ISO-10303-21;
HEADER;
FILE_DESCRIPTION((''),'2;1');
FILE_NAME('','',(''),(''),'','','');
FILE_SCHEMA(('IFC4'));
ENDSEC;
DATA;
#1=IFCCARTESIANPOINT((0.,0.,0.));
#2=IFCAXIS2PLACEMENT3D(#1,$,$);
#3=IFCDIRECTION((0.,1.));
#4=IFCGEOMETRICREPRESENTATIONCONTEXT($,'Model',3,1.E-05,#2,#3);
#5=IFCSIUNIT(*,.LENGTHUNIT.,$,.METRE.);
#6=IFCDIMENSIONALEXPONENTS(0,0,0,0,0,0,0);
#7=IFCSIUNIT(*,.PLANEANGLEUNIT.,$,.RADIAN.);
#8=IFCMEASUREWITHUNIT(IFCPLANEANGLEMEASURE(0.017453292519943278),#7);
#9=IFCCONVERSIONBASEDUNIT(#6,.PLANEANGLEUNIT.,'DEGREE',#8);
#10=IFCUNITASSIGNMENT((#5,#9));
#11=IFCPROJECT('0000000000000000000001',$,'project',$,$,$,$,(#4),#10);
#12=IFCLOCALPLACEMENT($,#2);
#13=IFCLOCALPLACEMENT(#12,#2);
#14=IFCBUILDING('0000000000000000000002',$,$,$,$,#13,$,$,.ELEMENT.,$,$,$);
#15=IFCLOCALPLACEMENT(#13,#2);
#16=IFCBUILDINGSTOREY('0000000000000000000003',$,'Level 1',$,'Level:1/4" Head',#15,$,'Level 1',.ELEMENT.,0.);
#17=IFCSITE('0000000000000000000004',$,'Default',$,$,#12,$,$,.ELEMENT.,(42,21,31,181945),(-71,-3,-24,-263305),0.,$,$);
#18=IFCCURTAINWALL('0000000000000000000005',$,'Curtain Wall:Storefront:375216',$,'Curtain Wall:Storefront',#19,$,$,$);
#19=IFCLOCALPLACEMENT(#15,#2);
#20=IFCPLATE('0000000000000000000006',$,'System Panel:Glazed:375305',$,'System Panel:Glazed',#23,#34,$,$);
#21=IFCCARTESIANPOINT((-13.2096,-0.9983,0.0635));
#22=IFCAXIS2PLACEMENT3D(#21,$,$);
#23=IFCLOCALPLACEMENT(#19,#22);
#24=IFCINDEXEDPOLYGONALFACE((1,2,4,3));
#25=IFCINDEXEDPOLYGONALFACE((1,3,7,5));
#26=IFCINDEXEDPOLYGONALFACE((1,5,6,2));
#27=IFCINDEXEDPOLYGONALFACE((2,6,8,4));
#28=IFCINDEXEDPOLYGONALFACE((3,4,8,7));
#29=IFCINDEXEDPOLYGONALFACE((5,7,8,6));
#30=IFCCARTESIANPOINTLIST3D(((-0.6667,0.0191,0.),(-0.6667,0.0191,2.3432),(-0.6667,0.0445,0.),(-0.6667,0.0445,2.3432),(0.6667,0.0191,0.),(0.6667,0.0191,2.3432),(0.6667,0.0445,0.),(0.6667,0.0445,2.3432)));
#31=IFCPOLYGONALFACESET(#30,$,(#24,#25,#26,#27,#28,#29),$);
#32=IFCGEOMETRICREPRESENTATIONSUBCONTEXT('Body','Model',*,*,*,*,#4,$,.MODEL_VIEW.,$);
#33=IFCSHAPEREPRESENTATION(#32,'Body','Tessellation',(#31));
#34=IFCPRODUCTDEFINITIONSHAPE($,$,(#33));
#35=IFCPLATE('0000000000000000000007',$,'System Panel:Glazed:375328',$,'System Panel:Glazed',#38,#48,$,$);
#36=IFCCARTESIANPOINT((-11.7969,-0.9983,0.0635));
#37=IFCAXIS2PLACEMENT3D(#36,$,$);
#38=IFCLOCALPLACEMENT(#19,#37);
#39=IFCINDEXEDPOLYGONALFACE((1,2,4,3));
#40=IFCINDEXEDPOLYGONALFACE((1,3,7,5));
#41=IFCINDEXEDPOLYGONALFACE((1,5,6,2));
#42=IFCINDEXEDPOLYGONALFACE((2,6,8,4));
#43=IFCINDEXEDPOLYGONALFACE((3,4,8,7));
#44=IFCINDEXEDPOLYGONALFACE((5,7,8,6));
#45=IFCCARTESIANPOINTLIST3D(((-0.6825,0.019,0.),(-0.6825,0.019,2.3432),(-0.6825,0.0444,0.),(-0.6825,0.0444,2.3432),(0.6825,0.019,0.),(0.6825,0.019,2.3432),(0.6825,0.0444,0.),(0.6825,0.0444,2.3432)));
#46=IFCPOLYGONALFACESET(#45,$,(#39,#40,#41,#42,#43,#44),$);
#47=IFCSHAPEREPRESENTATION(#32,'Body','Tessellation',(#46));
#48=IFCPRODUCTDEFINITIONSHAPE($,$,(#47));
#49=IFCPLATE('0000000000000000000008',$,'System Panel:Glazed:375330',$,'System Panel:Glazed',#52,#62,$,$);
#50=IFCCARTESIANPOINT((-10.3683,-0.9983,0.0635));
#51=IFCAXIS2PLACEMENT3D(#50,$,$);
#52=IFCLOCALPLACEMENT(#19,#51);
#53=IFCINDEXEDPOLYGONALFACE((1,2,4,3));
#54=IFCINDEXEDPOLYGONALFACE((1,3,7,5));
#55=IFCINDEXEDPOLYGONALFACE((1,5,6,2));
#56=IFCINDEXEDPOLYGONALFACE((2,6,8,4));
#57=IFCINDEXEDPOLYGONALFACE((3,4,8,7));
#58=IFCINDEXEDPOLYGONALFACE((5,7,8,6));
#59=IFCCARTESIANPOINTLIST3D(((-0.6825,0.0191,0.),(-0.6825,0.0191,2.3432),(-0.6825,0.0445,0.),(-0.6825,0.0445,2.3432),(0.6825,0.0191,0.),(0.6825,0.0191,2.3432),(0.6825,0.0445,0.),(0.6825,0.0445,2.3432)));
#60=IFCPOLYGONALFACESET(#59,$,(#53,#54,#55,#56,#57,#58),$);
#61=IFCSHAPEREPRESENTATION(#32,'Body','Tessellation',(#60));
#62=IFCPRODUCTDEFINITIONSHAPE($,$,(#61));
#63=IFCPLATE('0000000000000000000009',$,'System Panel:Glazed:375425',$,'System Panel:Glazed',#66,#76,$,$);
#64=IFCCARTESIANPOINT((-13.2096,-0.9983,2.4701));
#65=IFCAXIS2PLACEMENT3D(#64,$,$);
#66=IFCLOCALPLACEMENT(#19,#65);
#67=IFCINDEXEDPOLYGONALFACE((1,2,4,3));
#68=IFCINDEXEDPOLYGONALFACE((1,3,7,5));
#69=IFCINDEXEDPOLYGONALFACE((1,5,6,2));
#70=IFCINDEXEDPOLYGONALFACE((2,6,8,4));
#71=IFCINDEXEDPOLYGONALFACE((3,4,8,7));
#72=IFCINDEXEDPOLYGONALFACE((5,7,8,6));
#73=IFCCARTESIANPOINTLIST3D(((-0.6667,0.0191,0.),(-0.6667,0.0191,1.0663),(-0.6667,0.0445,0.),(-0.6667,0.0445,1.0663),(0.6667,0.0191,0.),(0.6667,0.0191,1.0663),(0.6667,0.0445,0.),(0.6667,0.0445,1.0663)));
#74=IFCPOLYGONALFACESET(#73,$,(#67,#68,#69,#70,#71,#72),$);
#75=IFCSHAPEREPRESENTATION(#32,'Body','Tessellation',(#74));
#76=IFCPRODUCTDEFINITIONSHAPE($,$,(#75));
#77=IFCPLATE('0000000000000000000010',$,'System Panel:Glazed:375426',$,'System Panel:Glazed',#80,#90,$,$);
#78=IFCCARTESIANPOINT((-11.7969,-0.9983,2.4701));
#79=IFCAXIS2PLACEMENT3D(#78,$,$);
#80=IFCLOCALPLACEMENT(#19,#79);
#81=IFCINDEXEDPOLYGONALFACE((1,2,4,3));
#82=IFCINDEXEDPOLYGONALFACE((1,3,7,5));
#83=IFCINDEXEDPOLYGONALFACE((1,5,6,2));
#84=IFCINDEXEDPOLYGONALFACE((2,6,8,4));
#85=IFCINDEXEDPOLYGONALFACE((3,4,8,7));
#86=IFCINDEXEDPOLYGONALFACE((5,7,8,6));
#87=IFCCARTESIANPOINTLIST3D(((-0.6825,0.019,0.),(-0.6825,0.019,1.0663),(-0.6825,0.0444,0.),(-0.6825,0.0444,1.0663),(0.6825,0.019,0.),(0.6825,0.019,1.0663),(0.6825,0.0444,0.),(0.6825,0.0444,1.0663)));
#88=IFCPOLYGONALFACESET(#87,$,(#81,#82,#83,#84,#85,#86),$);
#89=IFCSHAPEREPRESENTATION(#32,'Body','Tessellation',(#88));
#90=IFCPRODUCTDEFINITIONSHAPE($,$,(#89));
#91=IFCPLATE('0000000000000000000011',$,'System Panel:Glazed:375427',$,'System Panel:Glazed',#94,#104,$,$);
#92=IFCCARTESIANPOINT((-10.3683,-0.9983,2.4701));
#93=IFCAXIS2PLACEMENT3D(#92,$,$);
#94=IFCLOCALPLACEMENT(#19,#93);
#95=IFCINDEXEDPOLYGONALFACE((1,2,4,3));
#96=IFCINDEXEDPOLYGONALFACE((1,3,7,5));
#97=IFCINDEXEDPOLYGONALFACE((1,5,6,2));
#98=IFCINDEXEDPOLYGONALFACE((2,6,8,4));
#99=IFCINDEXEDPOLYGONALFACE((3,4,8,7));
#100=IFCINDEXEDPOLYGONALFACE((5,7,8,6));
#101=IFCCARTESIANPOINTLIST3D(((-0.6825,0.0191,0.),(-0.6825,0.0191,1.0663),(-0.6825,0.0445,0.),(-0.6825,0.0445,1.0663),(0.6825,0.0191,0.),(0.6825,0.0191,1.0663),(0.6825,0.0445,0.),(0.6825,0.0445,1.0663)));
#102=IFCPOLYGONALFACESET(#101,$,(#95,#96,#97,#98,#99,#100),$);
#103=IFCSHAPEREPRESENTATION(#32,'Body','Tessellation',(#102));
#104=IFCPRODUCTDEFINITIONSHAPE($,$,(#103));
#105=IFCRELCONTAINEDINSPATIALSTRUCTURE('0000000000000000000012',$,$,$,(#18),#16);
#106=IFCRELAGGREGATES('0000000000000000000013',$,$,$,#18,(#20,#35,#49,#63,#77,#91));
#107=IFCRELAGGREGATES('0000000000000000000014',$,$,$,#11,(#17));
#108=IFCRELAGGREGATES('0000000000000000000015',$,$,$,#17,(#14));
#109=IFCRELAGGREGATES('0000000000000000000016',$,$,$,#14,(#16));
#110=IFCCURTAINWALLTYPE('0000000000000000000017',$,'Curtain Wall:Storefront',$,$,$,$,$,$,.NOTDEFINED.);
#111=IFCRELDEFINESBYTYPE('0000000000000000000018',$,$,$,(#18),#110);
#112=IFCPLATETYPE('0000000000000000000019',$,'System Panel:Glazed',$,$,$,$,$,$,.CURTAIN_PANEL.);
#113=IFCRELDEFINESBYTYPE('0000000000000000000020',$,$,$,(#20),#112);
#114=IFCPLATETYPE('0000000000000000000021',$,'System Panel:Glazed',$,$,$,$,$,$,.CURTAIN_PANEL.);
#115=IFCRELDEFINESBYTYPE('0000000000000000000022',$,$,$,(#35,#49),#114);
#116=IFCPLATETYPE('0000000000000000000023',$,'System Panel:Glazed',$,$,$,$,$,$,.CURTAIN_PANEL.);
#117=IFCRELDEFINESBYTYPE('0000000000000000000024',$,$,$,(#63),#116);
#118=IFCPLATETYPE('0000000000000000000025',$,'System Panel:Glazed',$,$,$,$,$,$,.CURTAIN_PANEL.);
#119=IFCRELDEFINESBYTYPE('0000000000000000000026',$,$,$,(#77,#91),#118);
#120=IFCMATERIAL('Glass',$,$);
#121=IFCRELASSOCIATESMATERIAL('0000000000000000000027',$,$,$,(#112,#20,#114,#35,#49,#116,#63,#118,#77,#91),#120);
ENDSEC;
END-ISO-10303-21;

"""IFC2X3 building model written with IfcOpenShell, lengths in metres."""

from ifc_helpers import new_model, entity, si_unit, converted_unit, direction, frame, frame_2d, origin, place, context, subcontext, project, spatial, rectangle, extrude, source, transform, mapped, material, type_object, type_shapes, element, aggregate, save


model = new_model("IFC2X3")

# Units and contexts
model_context = context("Model", 3, precision=1e-05, world=origin(), true_north=direction((0.0, 1.0)))
body_context = subcontext(model_context, "Body", "Model", "MODEL_VIEW")
ifc_project = project(units=[si_unit("LENGTHUNIT", "METRE"), converted_unit("PLANEANGLEUNIT", "DEGREE", entity("IfcPlaneAngleMeasure", 0.017453292519943278), si_unit("PLANEANGLEUNIT", "RADIAN"), dimensions=[0, 0, 0, 0, 0, 0, 0])], contexts=[model_context])

# Site, building, storey
site_placement = place(None, origin())
site = spatial("IfcSite", under=ifc_project, at=site_placement, Name="Default", CompositionType="ELEMENT", RefLatitude=(42, 21, 31, 181945), RefLongitude=(-71, -3, -24, -263305), RefElevation=0.0)
building_placement = place(site_placement, origin())
building = spatial("IfcBuilding", under=site, at=building_placement, CompositionType="ELEMENT")
storey_placement = place(building_placement, origin())
storey = spatial("IfcBuildingStorey", under=building, at=storey_placement, Name="Level 1", ObjectType="Level:1/4\" Head", LongName="Level 1", CompositionType="ELEMENT", Elevation=0.0)

# Curtain wall, plates
curtain_wall_type = type_object("IfcCurtainWallType", Name="Curtain Wall:Storefront", PredefinedType="NOTDEFINED")
curtain_wall_placement = place(storey_placement, origin())
curtain_wall = element("IfcCurtainWall", 1, at=curtain_wall_placement, inside=storey, type_object=curtain_wall_type, Name="Curtain Wall:Storefront:375216", ObjectType="Curtain Wall:Storefront")
ifc_material_1 = material(Name="Glass")
plate_type_1 = type_object("IfcPlateType", Name="System Panel:Glazed", PredefinedType="CURTAIN_PANEL", material=ifc_material_1)
shared_shape_1 = source(origin(), body_context, "Body", "SweptSolid", [
    extrude(rectangle(XDim=0.0254, YDim=1.3333, at=frame_2d((0.0, 0.0), x_axis=(1.0, 0.0))), frame((0.0, 0.0318, 0.0), z_axis=(0.0, 0.0, 1.0), x_axis=(0.0, 1.0, 0.0)), (0.0, 0.0, 1.0), 2.3432),
])
type_shapes(plate_type_1, [shared_shape_1])
plate_1_placement = place(curtain_wall_placement, frame((-13.2096, -0.9983, 0.0635)))
plate_1 = element("IfcPlate", 2, at=plate_1_placement, type_object=plate_type_1, material=ifc_material_1, Name="System Panel:Glazed:375305", ObjectType="System Panel:Glazed", context=body_context, shape_type="MappedRepresentation", body=[
    mapped(shared_shape_1, transform((0.0, 0.0, 0.0), scale=1.0)),
])
plate_type_2 = type_object("IfcPlateType", Name="System Panel:Glazed", PredefinedType="CURTAIN_PANEL", material=ifc_material_1)
shared_shape_2 = source(origin(), body_context, "Body", "SweptSolid", [
    extrude(rectangle(XDim=0.0254, YDim=1.3651, at=frame_2d((0.0, 0.0), x_axis=(1.0, 0.0))), frame((0.0, 0.0318, 0.0), z_axis=(0.0, 0.0, 1.0), x_axis=(0.0, 1.0, 0.0)), (0.0, 0.0, 1.0), 2.3432),
])
type_shapes(plate_type_2, [shared_shape_2])
plate_2_placement = place(curtain_wall_placement, frame((-11.7969, -0.9983, 0.0635)))
plate_2 = element("IfcPlate", 3, at=plate_2_placement, type_object=plate_type_2, material=ifc_material_1, Name="System Panel:Glazed:375328", ObjectType="System Panel:Glazed", context=body_context, shape_type="MappedRepresentation", body=[
    mapped(shared_shape_2, transform((0.0, 0.0, 0.0), scale=1.0)),
])
plate_3_placement = place(curtain_wall_placement, frame((-10.3683, -0.9983, 0.0635)))
plate_3 = element("IfcPlate", 4, at=plate_3_placement, type_object=plate_type_2, material=ifc_material_1, Name="System Panel:Glazed:375330", ObjectType="System Panel:Glazed", context=body_context, shape_type="MappedRepresentation", body=[
    mapped(shared_shape_2, transform((0.0, 0.0, 0.0), scale=1.0)),
])
plate_type_3 = type_object("IfcPlateType", Name="System Panel:Glazed", PredefinedType="CURTAIN_PANEL", material=ifc_material_1)
shared_shape_3 = source(origin(), body_context, "Body", "SweptSolid", [
    extrude(rectangle(XDim=0.0254, YDim=1.3333, at=frame_2d((0.0, 0.0), x_axis=(1.0, 0.0))), frame((0.0, 0.0318, 0.0), z_axis=(0.0, 0.0, 1.0), x_axis=(0.0, 1.0, 0.0)), (0.0, 0.0, 1.0), 1.0663),
])
type_shapes(plate_type_3, [shared_shape_3])
plate_4_placement = place(curtain_wall_placement, frame((-13.2096, -0.9983, 2.4701)))
plate_4 = element("IfcPlate", 5, at=plate_4_placement, type_object=plate_type_3, material=ifc_material_1, Name="System Panel:Glazed:375425", ObjectType="System Panel:Glazed", context=body_context, shape_type="MappedRepresentation", body=[
    mapped(shared_shape_3, transform((0.0, 0.0, 0.0), scale=1.0)),
])
plate_type_4 = type_object("IfcPlateType", Name="System Panel:Glazed", PredefinedType="CURTAIN_PANEL", material=ifc_material_1)
shared_shape_4 = source(origin(), body_context, "Body", "SweptSolid", [
    extrude(rectangle(XDim=0.0254, YDim=1.3651, at=frame_2d((0.0, 0.0), x_axis=(1.0, 0.0))), frame((0.0, 0.0318, 0.0), z_axis=(0.0, 0.0, 1.0), x_axis=(0.0, 1.0, 0.0)), (0.0, 0.0, 1.0), 1.0663),
])
type_shapes(plate_type_4, [shared_shape_4])
plate_5_placement = place(curtain_wall_placement, frame((-11.7969, -0.9983, 2.4701)))
plate_5 = element("IfcPlate", 6, at=plate_5_placement, type_object=plate_type_4, material=ifc_material_1, Name="System Panel:Glazed:375426", ObjectType="System Panel:Glazed", context=body_context, shape_type="MappedRepresentation", body=[
    mapped(shared_shape_4, transform((0.0, 0.0, 0.0), scale=1.0)),
])
plate_6_placement = place(curtain_wall_placement, frame((-10.3683, -0.9983, 2.4701)))
plate_6 = element("IfcPlate", 7, at=plate_6_placement, type_object=plate_type_4, material=ifc_material_1, Name="System Panel:Glazed:375427", ObjectType="System Panel:Glazed", context=body_context, shape_type="MappedRepresentation", body=[
    mapped(shared_shape_4, transform((0.0, 0.0, 0.0), scale=1.0)),
])
aggregate(curtain_wall, [plate_1, plate_2, plate_3, plate_4, plate_5, plate_6])

save(model, "model.ifc")
